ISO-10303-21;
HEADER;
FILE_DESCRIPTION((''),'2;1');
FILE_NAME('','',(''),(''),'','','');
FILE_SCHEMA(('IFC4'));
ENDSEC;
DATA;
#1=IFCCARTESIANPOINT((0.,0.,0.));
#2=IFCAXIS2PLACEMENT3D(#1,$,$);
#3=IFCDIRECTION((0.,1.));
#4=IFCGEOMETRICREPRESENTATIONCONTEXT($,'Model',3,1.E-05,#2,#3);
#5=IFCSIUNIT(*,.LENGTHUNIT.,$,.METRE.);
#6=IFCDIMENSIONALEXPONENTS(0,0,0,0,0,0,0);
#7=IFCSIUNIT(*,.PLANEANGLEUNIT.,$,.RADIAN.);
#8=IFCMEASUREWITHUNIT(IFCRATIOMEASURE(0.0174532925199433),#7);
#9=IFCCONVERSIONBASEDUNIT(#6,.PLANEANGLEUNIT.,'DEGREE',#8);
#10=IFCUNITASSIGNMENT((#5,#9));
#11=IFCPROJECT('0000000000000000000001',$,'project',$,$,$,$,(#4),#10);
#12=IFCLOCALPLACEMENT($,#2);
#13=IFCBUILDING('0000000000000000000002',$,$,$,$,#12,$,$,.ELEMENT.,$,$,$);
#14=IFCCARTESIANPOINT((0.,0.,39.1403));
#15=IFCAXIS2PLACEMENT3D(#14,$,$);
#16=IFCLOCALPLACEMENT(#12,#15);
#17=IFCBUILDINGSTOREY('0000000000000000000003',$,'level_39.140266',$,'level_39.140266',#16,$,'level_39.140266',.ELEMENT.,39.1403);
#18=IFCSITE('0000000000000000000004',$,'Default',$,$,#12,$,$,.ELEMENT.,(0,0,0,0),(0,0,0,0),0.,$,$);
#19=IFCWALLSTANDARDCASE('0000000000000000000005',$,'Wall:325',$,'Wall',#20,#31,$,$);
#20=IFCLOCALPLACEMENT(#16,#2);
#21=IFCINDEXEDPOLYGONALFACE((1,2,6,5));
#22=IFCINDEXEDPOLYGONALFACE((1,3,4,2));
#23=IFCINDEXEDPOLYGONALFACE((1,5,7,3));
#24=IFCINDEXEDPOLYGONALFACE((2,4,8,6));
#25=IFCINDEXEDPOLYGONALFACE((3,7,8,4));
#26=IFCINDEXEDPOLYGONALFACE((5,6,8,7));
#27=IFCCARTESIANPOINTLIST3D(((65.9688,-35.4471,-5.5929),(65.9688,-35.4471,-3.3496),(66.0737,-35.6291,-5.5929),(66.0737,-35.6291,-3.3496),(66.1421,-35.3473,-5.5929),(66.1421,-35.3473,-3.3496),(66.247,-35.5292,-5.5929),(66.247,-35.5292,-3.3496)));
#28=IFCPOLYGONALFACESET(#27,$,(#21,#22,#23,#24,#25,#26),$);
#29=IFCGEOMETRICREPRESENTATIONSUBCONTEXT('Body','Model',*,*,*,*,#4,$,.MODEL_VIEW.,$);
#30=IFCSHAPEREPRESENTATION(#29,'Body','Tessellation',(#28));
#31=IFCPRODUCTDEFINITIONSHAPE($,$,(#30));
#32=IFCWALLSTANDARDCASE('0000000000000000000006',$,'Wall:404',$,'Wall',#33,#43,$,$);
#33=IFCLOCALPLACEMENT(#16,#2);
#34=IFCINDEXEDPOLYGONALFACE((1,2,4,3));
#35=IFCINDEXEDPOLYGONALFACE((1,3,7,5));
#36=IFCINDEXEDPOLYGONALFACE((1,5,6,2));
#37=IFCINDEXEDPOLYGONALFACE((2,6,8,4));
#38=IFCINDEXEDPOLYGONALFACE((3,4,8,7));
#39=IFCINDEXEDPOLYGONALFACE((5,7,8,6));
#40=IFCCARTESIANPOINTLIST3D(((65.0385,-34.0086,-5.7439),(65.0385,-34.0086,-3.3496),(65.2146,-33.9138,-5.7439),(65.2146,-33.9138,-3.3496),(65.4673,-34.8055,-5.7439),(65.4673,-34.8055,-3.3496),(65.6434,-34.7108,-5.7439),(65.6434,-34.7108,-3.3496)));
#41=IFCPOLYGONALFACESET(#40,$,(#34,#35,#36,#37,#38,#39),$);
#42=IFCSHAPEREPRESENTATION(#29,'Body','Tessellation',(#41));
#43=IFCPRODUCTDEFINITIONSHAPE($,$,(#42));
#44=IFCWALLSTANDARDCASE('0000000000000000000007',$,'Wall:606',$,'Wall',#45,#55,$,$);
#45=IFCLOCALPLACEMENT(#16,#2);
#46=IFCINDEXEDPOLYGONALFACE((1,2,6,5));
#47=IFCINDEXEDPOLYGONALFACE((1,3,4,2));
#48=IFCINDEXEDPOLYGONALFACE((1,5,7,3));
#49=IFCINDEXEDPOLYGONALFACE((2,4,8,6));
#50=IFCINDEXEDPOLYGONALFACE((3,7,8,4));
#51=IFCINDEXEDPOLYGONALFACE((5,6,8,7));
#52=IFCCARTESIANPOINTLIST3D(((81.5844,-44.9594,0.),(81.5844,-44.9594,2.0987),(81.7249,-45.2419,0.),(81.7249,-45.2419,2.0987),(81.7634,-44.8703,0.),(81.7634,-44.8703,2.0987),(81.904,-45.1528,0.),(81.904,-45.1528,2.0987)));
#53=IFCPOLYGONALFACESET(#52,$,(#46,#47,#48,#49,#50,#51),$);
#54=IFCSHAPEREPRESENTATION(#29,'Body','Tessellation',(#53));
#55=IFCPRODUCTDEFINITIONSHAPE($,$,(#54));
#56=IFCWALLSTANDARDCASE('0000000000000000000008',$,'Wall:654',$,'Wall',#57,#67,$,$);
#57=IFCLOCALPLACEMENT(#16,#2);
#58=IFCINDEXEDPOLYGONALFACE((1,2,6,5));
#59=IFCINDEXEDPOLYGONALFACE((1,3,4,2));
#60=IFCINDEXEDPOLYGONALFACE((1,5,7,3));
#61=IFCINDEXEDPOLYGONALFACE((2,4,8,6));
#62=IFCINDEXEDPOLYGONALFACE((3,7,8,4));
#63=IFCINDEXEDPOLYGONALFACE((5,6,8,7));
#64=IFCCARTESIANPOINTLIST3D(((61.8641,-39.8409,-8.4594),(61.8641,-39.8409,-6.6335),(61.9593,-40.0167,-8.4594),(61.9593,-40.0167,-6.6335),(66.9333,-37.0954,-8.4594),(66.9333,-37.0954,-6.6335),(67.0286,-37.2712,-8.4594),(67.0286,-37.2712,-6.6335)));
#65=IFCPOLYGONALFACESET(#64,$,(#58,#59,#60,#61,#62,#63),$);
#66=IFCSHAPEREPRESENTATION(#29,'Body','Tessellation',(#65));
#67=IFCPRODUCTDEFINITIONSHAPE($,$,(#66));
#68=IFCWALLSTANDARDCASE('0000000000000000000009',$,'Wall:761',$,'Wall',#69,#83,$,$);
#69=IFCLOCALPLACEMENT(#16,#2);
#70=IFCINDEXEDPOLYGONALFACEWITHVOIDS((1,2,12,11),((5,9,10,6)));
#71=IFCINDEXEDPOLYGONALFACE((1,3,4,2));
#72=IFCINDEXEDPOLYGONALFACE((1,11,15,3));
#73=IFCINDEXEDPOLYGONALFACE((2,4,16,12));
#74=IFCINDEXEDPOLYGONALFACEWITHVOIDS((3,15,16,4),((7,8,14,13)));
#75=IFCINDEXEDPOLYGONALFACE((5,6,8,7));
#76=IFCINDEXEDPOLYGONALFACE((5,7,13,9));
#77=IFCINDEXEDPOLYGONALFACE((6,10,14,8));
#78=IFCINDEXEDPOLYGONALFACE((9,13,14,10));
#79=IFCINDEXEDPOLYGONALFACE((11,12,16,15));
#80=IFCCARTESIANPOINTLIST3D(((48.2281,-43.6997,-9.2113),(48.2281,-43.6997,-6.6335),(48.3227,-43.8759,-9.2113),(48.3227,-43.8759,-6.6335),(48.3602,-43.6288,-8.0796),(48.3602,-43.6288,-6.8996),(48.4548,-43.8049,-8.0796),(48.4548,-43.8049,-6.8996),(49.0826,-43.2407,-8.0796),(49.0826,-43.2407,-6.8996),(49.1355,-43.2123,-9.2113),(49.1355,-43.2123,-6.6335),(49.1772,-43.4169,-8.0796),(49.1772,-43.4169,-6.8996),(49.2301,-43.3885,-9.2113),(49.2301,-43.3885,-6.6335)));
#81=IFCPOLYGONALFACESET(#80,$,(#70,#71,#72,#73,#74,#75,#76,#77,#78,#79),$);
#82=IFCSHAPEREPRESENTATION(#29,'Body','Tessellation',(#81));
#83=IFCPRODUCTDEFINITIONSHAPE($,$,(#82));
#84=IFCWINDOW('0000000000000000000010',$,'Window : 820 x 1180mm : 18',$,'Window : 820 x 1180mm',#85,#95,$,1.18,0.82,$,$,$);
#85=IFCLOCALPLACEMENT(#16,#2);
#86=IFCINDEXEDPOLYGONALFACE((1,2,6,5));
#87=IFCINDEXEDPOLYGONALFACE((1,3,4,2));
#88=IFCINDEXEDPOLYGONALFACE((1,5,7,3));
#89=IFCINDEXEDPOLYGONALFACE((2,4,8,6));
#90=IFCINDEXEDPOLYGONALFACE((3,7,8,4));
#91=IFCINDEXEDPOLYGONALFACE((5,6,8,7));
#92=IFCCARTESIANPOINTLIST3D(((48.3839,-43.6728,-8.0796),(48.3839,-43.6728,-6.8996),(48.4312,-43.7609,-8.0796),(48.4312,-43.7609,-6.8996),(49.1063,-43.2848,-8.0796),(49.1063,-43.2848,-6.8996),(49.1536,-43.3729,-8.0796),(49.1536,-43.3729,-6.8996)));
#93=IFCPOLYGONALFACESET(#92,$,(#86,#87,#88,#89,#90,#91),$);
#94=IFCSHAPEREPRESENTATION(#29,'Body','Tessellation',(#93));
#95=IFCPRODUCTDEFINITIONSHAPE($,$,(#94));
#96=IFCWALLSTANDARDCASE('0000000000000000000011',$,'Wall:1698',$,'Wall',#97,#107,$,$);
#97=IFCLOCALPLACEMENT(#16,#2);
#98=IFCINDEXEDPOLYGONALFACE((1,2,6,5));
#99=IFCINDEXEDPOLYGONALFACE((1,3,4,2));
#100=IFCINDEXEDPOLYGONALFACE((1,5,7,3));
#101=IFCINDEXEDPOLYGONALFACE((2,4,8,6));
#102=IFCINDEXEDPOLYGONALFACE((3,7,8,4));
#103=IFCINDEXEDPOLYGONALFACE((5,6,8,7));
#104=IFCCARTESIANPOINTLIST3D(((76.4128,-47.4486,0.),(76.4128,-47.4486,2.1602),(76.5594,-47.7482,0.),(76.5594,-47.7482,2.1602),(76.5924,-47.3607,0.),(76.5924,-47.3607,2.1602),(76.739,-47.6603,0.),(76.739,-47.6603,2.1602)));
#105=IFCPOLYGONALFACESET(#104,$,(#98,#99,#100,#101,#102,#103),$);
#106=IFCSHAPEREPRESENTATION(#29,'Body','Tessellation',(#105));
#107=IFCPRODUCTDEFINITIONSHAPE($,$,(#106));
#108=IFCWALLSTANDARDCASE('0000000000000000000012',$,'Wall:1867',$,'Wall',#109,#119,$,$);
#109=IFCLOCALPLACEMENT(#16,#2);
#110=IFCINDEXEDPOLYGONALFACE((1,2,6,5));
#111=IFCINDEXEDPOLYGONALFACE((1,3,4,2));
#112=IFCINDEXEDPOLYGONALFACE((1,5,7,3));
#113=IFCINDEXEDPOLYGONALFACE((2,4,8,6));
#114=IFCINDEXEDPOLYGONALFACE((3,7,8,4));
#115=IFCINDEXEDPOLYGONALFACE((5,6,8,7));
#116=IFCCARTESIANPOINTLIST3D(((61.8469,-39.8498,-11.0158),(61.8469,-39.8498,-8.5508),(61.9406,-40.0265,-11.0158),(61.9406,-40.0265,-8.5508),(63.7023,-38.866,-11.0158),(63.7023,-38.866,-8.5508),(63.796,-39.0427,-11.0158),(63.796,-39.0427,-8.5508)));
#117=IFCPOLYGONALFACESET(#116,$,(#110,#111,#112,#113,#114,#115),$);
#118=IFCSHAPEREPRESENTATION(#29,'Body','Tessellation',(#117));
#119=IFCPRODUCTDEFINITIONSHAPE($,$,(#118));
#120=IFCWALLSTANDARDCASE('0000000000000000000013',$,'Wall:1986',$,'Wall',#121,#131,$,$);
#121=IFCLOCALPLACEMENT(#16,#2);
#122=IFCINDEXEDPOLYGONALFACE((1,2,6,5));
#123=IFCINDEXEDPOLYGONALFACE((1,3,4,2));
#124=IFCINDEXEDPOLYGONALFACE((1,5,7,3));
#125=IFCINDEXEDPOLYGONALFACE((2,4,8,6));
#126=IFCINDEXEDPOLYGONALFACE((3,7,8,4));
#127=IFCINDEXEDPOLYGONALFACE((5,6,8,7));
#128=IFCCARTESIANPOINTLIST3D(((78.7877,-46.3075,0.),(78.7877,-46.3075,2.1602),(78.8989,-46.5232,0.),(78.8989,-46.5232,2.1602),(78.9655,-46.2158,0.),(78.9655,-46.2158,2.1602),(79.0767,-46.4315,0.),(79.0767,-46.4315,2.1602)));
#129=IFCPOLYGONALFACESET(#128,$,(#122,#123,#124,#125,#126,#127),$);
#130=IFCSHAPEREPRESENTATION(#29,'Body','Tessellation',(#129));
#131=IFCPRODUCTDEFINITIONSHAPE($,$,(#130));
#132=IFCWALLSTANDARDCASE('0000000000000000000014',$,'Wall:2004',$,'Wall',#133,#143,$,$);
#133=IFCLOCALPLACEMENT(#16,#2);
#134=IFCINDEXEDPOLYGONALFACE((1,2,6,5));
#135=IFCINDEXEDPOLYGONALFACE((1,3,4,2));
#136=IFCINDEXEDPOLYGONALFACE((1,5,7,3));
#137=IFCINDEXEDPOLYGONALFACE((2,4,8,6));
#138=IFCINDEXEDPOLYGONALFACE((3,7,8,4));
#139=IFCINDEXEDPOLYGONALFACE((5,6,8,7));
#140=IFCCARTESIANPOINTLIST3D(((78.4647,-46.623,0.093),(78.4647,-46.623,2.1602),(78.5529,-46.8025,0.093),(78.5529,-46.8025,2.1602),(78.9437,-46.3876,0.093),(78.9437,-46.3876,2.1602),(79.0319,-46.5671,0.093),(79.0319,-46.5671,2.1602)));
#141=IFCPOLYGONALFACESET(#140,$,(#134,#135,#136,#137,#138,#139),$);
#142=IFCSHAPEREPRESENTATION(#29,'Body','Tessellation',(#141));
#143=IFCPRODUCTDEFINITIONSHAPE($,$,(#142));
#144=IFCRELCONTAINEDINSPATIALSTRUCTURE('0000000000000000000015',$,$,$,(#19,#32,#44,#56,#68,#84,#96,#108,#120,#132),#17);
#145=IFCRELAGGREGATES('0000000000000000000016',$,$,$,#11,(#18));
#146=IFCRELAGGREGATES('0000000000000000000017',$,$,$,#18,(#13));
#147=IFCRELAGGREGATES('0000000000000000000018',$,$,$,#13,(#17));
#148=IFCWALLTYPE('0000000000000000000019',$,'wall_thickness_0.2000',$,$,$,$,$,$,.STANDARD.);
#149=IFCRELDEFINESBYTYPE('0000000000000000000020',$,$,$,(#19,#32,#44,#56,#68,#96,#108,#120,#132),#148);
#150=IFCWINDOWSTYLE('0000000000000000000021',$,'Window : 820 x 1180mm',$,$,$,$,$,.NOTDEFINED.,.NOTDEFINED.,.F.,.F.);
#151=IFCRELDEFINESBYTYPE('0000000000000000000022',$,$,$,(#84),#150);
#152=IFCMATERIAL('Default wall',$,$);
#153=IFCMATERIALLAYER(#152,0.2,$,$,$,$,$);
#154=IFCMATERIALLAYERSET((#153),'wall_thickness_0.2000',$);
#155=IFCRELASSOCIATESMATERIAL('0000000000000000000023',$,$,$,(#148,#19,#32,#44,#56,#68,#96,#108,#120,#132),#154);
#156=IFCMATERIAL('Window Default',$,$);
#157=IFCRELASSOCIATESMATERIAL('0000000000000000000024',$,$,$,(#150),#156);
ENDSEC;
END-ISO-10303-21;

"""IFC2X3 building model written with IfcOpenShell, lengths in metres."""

from ifc_helpers import new_model, entity, si_unit, converted_unit, direction, frame, frame_2d, origin, origin_2d_with_axis, place, context, subcontext, project, spatial, polyline, rectangle, outline, extrude, source, transform, mapped, material, layer, layer_set, layer_usage, type_object, type_shapes, element, fill, save


model = new_model("IFC2X3")

# Units and contexts
model_context = context("Model", 3, precision=1e-05, world=origin(), true_north=direction((0.0, 1.0)))
body_context = subcontext(model_context, "Body", "Model", "MODEL_VIEW")
ifc_project = project(units=[si_unit("LENGTHUNIT", "METRE"), converted_unit("PLANEANGLEUNIT", "DEGREE", entity("IfcRatioMeasure", 0.0174532925199433), si_unit("PLANEANGLEUNIT", "RADIAN"), dimensions=[0, 0, 0, 0, 0, 0, 0])], contexts=[model_context])

# Site, building, storey
placement_1 = place(None, origin())
site = spatial("IfcSite", under=ifc_project, at=placement_1, Name="Default", CompositionType="ELEMENT", RefLatitude=(0, 0, 0, 0), RefLongitude=(0, 0, 0, 0), RefElevation=0.0)
building = spatial("IfcBuilding", under=site, at=placement_1, CompositionType="ELEMENT")
storey_placement = place(placement_1, frame((0.0, 0.0, 39.1403)))
storey = spatial("IfcBuildingStorey", under=building, at=storey_placement, Name="level_39.140266", ObjectType="level_39.140266", LongName="level_39.140266", CompositionType="ELEMENT", Elevation=39.1403)

# Walls
ifc_material_1 = material(Name="Default wall")
ifc_layer = layer(ifc_material_1, 0.2)
ifc_layer_set = layer_set([ifc_layer], Name="wall_thickness_0.2000")
ifc_layer_usage = layer_usage(ifc_layer_set, "AXIS2", "POSITIVE", -0.1)
wall_type = type_object("IfcWallType", Name="wall_thickness_0.2000", PredefinedType="STANDARD", material=ifc_layer_set)
placement_2 = place(placement_1, frame((0.0, 0.0, 33.5474)))
wall_1_placement = place(placement_2, frame((66.1603, -35.5792, 0.0), z_axis=(0.0, 0.0, 1.0), x_axis=(-0.499172, 0.866503, 0.0)))
element("IfcWallStandardCase", 1, at=wall_1_placement, inside=storey, type_object=wall_type, material=ifc_layer_usage, Name="Wall:325", ObjectType="Wall", context=body_context, shape_type="SweptSolid", body=[
    extrude(outline(polyline([(0.21, -0.1), (0.21, 0.1), (0.0, 0.1), (0.0, -0.1), (0.21, -0.1)])), origin(), (0.0, 0.0, 1.0), 2.2433),
])
placement_3 = place(placement_1, frame((0.0, 0.0, 33.3964)))
wall_2_placement = place(placement_3, frame((65.5553, -34.7582, 0.0), z_axis=(0.0, 0.0, 1.0), x_axis=(-0.473816, 0.880624, 0.0)))
element("IfcWallStandardCase", 2, at=wall_2_placement, inside=storey, type_object=wall_type, material=ifc_layer_usage, Name="Wall:404", ObjectType="Wall", context=body_context, shape_type="SweptSolid", body=[
    extrude(outline(polyline([(0.905, -0.1), (0.905, 0.1), (0.0, 0.1), (0.0, -0.1), (0.905, -0.1)])), origin(), (0.0, 0.0, 1.0), 2.3943),
])
wall_3_placement = place(storey_placement, frame((81.8144, -45.1973, 0.0), z_axis=(0.0, 0.0, 1.0), x_axis=(-0.445462, 0.895301, 0.0)))
element("IfcWallStandardCase", 3, at=wall_3_placement, inside=storey, type_object=wall_type, material=ifc_layer_usage, Name="Wall:606", ObjectType="Wall", context=body_context, shape_type="SweptSolid", body=[
    extrude(outline(polyline([(0.3155, -0.1), (0.3155, 0.1), (0.0, 0.1), (0.0, -0.1), (0.3155, -0.1)])), origin(), (0.0, 0.0, 1.0), 2.0987),
])
placement_4 = place(placement_1, frame((0.0, 0.0, 30.6809)))
wall_4_placement = place(placement_4, frame((61.9117, -39.9288, 0.0), z_axis=(0.0, 0.0, 1.0), x_axis=(0.879317, 0.476236, 0.0)))
element("IfcWallStandardCase", 4, at=wall_4_placement, inside=storey, type_object=wall_type, material=ifc_layer_usage, Name="Wall:654", ObjectType="Wall", context=body_context, shape_type="SweptSolid", body=[
    extrude(outline(polyline([(5.765, -0.1), (5.765, 0.1), (0.0, 0.1), (0.0, -0.1), (5.765, -0.1)])), origin(), (0.0, 0.0, 1.0), 1.8259),
])

# Wall, opening, window
placement_5 = place(placement_1, frame((0.0, 0.0, 29.929)))
wall_5_placement = place(placement_5, frame((48.2754, -43.7878, 0.0), z_axis=(0.0, 0.0, 1.0), x_axis=(0.880961, 0.473189, 0.0)))
wall_5 = element("IfcWallStandardCase", 5, at=wall_5_placement, inside=storey, type_object=wall_type, material=ifc_layer_usage, Name="Wall:761", ObjectType="Wall", context=body_context, shape_type="SweptSolid", body=[
    extrude(outline(polyline([(1.03, -0.1), (1.03, 0.1), (0.0, 0.1), (0.0, -0.1), (1.03, -0.1)])), origin(), (0.0, 0.0, 1.0), 2.5778),
])
opening_placement = place(wall_5_placement, frame((0.15, -0.1, 1.1317)))
opening = element("IfcOpeningElement", 6, at=opening_placement, cuts=wall_5, ObjectType="Opening", context=body_context, shape_type="SweptSolid", body=[
    extrude(rectangle(XDim=0.82, YDim=1.18, at=frame_2d((0.59, 0.41), x_axis=(0.0, 1.0))), frame((0.0, 0.0, 0.0), z_axis=(0.0, 1.0, 0.0), x_axis=(0.0, 0.0, 1.0)), (0.0, 0.0, 1.0), 0.2),
])
ifc_material_2 = material(Name="Window Default")
window_style = type_object("IfcWindowStyle", Name="Window : 820 x 1180mm", ConstructionType="NOTDEFINED", OperationType="NOTDEFINED", ParameterTakesPrecedence=False, Sizeable=False, material=ifc_material_2)
shared_shape = source(origin(), body_context, "Body", "SweptSolid", [
    extrude(rectangle(XDim=0.1, YDim=0.82, at=origin_2d_with_axis()), frame((0.41, 0.1, 0.0), z_axis=(0.0, 0.0, 1.0), x_axis=(0.0, 1.0, 0.0)), (0.0, 0.0, 1.0), 1.18),
])
type_shapes(window_style, [shared_shape])
window_placement = place(opening_placement, origin())
window = element("IfcWindow", 7, at=window_placement, inside=storey, type_object=window_style, Name="Window : 820 x 1180mm : 18", ObjectType="Window : 820 x 1180mm", OverallHeight=1.18, OverallWidth=0.82, context=body_context, shape_type="MappedRepresentation", body=[
    mapped(shared_shape, transform((0.0, 0.0, 0.0), scale=1.0)),
])
fill(opening, window)

# Walls
wall_6_placement = place(storey_placement, frame((76.5026, -47.4047, 0.0), z_axis=(0.0, 0.0, 1.0), x_axis=(0.439553, -0.898217, 0.0)))
element("IfcWallStandardCase", 8, at=wall_6_placement, inside=storey, type_object=wall_type, material=ifc_layer_usage, Name="Wall:1698", ObjectType="Wall", context=body_context, shape_type="SweptSolid", body=[
    extrude(outline(polyline([(0.3336, -0.1), (0.3336, 0.1), (0.0, 0.1), (0.0, -0.1), (0.3336, -0.1)])), origin(), (0.0, 0.0, 1.0), 2.1602),
])
placement_6 = place(placement_1, frame((0.0, 0.0, 28.1245)))
wall_7_placement = place(placement_6, frame((61.8938, -39.9382, 0.0), z_axis=(0.0, 0.0, 1.0), x_axis=(0.883483, 0.468463, 0.0)))
element("IfcWallStandardCase", 9, at=wall_7_placement, inside=storey, type_object=wall_type, material=ifc_layer_usage, Name="Wall:1867", ObjectType="Wall", context=body_context, shape_type="SweptSolid", body=[
    extrude(outline(polyline([(2.1, -0.1), (2.1, 0.1), (0.0, 0.1), (0.0, -0.1), (2.1, -0.1)])), origin(), (0.0, 0.0, 1.0), 2.465),
])
wall_8_placement = place(storey_placement, frame((78.9878, -46.4773, 0.0), z_axis=(0.0, 0.0, 1.0), x_axis=(-0.458203, 0.888847, 0.0)))
element("IfcWallStandardCase", 10, at=wall_8_placement, inside=storey, type_object=wall_type, material=ifc_layer_usage, Name="Wall:1986", ObjectType="Wall", context=body_context, shape_type="SweptSolid", body=[
    extrude(outline(polyline([(0.2427, -0.1), (0.2427, 0.1), (0.0, 0.1), (0.0, -0.1), (0.2427, -0.1)])), origin(), (0.0, 0.0, 1.0), 2.1602),
])
placement_7 = place(placement_1, frame((0.0, 0.0, 39.2333)))
wall_9_placement = place(placement_7, frame((78.5088, -46.7128, 0.0), z_axis=(0.0, 0.0, 1.0), x_axis=(0.897473, 0.441068, 0.0)))
element("IfcWallStandardCase", 11, at=wall_9_placement, inside=storey, type_object=wall_type, material=ifc_layer_usage, Name="Wall:2004", ObjectType="Wall", context=body_context, shape_type="SweptSolid", body=[
    extrude(outline(polyline([(0.5338, -0.1), (0.5338, 0.1), (0.0, 0.1), (0.0, -0.1), (0.5338, -0.1)])), origin(), (0.0, 0.0, 1.0), 2.0672),
])

save(model, "model.ifc")
